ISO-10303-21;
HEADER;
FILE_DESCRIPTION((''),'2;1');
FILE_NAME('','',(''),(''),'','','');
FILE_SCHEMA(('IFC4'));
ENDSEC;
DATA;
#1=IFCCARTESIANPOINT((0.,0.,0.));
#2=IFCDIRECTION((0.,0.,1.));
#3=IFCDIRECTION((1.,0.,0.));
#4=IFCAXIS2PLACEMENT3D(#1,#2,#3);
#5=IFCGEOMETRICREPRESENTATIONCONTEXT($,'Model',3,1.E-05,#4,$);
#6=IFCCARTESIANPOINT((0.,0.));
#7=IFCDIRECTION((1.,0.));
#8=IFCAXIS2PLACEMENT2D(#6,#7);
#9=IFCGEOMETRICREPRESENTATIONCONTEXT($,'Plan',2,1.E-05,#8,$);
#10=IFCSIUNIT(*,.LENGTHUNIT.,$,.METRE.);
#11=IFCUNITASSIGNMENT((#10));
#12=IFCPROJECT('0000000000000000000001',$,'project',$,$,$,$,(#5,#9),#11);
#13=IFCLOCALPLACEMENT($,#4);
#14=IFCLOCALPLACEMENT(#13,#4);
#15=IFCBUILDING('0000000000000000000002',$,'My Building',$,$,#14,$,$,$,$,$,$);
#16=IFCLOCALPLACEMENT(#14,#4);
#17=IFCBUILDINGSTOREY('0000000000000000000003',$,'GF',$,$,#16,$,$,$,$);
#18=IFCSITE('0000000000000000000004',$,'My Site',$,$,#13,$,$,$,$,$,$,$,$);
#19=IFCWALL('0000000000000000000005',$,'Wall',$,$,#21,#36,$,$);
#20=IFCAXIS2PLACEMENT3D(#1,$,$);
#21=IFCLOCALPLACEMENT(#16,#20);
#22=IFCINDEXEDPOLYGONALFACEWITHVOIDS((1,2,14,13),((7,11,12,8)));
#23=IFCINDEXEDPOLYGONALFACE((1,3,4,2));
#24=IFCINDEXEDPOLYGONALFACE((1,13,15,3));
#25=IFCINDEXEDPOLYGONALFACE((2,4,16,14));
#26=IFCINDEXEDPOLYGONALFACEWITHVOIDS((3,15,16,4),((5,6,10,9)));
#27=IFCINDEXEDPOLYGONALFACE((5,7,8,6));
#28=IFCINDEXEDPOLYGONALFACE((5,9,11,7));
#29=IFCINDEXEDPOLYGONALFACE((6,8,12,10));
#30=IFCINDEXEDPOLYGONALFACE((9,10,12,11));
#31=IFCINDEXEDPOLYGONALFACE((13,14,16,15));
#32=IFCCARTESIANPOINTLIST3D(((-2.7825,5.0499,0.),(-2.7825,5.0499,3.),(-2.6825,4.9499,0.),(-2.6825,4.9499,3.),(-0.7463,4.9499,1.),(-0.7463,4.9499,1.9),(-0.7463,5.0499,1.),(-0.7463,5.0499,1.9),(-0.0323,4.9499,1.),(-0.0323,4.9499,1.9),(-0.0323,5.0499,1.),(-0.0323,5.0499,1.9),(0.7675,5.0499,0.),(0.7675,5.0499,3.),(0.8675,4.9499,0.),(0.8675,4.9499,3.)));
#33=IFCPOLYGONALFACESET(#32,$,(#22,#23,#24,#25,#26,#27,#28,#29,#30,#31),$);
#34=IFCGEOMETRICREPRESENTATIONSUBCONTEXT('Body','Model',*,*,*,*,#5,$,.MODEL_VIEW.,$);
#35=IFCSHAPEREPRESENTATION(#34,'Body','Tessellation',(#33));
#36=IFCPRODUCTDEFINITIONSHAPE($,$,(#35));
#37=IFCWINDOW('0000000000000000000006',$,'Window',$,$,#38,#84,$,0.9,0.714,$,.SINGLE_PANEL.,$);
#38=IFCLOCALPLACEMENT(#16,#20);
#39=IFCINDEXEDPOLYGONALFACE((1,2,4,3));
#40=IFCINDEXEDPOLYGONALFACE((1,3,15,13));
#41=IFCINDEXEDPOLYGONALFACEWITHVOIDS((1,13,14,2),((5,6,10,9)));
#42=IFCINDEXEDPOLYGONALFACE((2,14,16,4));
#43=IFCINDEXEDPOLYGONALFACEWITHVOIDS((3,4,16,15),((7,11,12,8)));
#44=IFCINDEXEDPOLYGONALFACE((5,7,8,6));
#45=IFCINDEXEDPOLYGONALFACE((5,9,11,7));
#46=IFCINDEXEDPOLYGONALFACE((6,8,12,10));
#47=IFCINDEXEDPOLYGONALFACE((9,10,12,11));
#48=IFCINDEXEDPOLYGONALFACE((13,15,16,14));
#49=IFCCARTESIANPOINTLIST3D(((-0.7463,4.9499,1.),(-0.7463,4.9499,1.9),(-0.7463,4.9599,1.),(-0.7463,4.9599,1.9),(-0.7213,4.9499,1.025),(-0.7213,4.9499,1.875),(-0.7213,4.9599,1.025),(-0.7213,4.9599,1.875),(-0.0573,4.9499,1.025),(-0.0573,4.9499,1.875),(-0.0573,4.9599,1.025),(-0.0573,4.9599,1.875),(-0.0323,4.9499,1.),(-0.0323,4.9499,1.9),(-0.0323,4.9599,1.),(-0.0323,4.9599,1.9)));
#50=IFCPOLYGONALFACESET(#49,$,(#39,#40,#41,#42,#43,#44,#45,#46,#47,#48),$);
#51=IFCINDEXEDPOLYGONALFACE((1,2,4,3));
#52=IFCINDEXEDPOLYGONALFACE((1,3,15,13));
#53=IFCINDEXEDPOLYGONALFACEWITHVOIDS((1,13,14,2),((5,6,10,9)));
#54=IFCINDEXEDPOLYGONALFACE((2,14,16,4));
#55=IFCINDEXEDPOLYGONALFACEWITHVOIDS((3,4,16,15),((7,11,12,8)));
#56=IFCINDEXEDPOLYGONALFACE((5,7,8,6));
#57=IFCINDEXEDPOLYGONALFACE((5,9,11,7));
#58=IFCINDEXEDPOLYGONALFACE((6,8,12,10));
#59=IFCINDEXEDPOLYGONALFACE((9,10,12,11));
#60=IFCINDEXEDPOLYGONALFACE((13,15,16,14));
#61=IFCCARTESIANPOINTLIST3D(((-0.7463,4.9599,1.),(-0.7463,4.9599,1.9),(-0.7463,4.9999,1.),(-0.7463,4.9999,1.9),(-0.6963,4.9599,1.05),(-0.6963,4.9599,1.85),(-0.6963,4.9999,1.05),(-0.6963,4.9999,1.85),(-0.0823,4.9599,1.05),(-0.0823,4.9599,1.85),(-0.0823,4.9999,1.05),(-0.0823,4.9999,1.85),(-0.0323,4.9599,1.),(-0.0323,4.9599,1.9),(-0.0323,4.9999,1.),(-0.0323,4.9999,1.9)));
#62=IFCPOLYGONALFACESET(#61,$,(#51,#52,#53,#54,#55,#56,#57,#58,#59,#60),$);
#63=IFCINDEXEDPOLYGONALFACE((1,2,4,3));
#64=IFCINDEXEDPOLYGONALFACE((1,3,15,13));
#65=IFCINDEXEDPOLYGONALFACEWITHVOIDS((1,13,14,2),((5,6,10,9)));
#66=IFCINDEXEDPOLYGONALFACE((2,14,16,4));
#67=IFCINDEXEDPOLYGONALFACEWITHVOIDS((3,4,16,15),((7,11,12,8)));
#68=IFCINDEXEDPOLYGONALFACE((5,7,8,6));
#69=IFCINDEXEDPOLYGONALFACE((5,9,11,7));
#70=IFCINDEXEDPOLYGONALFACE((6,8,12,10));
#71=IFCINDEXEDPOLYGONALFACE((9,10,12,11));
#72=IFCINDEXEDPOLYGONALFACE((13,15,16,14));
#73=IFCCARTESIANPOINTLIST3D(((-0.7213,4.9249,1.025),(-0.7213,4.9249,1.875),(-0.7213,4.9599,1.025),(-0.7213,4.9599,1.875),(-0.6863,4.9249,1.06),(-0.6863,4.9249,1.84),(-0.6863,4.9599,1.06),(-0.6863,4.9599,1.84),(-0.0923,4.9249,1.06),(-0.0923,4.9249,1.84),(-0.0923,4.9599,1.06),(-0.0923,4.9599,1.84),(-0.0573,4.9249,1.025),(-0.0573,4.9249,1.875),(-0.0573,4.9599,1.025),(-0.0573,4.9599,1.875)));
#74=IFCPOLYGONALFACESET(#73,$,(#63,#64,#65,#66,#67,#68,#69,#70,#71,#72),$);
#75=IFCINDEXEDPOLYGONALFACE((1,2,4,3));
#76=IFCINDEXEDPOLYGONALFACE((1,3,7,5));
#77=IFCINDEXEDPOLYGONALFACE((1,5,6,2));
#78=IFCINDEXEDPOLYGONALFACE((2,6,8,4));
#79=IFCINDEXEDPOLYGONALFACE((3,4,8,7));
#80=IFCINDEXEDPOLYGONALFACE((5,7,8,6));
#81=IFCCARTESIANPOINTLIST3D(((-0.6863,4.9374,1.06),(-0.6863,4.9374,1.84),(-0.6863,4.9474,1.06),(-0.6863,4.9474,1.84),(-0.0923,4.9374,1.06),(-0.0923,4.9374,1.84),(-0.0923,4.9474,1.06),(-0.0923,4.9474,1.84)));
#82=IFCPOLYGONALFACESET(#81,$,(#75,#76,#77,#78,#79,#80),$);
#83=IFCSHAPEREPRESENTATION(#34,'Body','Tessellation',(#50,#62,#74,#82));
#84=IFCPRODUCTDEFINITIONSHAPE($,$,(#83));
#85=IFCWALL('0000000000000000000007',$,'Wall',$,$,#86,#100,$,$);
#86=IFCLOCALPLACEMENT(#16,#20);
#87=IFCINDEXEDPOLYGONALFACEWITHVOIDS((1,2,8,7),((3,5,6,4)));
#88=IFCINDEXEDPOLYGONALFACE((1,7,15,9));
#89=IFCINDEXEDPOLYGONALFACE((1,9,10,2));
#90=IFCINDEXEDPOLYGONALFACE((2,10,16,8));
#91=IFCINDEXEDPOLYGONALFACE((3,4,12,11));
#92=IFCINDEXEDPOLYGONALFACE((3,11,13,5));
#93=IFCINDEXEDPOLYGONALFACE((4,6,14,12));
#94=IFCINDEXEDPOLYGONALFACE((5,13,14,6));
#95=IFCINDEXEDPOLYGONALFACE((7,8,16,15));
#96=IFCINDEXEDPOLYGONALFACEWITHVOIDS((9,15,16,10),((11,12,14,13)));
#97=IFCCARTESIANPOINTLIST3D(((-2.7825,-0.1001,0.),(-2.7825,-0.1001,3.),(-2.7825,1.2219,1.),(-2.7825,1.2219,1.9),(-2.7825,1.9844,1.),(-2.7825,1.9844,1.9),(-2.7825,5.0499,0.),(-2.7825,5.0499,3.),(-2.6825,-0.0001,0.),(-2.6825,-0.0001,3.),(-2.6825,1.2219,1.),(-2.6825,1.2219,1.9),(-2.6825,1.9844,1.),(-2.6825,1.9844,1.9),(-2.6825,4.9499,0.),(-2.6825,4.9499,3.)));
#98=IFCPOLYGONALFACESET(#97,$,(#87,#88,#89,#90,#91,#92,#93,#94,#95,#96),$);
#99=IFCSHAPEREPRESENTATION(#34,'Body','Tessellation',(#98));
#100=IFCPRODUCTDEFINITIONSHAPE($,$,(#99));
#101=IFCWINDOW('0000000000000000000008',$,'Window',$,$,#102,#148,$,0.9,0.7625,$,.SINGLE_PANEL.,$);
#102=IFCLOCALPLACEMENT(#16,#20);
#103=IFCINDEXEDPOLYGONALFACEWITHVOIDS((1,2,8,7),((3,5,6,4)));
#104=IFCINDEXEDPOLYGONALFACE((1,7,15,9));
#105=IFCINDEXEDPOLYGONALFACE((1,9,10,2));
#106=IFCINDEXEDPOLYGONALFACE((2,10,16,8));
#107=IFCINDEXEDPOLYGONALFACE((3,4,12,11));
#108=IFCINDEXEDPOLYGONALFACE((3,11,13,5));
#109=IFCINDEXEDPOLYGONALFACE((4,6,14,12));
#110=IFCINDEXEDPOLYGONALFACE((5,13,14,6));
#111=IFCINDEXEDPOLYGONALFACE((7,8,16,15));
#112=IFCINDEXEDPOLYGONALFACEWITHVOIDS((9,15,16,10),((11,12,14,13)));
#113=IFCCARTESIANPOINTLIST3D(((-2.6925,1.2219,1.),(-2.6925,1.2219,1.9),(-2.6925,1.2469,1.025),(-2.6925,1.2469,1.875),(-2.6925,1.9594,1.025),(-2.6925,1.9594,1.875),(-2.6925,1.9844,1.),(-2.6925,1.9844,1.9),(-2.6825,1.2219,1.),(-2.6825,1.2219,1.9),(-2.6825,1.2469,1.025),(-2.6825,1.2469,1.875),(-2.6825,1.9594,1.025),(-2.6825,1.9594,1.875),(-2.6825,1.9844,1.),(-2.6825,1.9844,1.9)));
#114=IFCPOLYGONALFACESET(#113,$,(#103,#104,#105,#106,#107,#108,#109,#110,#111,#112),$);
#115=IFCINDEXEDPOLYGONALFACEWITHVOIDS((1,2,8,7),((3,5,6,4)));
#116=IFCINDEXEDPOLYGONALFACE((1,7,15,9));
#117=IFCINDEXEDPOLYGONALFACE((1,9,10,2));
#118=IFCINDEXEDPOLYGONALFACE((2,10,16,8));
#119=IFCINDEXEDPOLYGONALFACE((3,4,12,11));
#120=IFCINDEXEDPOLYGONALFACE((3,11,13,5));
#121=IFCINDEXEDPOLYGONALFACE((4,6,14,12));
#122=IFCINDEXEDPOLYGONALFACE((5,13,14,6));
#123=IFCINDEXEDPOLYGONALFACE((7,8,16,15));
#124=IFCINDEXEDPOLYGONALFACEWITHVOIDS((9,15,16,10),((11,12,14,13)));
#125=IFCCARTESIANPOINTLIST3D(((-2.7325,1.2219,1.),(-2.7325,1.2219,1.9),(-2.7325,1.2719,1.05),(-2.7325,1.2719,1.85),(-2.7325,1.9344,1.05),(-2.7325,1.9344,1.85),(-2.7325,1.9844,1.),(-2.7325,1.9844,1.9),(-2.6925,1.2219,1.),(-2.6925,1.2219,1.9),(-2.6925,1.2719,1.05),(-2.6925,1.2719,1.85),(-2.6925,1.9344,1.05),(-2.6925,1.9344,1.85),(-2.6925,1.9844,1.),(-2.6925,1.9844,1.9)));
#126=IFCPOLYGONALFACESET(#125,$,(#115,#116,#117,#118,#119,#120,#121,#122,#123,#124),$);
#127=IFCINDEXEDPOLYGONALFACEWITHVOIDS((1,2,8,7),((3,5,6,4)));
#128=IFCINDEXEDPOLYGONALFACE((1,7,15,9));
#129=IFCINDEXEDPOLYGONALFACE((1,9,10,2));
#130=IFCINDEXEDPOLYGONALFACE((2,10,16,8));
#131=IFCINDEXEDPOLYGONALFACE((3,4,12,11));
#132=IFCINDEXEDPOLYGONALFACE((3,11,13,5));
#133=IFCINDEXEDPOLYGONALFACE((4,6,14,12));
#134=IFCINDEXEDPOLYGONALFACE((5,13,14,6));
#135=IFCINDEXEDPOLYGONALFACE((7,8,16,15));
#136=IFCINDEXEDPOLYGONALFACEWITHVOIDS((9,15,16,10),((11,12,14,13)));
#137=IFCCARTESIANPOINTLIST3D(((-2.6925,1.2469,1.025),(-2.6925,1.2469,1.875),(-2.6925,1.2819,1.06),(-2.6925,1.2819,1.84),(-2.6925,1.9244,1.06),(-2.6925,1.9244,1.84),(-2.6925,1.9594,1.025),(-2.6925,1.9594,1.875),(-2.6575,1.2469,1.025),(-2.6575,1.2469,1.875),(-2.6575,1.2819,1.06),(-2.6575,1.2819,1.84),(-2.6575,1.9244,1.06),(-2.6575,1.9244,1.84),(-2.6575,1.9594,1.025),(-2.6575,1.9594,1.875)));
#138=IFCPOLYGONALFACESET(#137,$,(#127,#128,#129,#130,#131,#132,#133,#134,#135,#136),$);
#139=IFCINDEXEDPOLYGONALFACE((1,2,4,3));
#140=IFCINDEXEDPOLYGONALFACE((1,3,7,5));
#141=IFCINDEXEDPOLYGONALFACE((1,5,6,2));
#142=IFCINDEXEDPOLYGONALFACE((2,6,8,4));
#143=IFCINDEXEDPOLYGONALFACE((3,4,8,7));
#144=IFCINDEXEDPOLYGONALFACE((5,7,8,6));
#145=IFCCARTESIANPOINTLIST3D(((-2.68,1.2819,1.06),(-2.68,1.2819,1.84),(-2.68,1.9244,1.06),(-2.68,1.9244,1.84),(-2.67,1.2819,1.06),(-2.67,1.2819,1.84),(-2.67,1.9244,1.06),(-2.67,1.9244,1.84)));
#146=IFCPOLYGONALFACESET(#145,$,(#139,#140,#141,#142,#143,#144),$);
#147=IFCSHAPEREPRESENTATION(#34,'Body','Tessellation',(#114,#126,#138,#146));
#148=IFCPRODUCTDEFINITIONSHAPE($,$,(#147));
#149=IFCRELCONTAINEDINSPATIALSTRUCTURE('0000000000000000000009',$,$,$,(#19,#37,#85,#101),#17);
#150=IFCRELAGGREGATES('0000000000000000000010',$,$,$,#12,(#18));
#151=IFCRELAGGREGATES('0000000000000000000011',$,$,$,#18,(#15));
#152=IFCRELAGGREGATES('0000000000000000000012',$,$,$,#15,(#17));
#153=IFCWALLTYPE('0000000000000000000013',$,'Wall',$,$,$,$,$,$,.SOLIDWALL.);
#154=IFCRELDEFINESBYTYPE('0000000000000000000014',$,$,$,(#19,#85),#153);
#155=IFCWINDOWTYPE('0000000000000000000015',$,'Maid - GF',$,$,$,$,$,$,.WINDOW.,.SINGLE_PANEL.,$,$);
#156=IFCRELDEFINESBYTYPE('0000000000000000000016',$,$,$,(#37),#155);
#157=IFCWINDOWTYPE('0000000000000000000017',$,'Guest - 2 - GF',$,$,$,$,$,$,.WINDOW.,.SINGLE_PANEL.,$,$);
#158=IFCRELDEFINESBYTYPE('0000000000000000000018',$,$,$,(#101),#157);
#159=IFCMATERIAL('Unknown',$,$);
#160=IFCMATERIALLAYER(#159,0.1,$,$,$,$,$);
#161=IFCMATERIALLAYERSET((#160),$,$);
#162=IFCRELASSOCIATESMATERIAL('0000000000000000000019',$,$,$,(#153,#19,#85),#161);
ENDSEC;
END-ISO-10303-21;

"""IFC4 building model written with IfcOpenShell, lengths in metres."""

from ifc_helpers import new_model, entity, si_unit, frame, origin_with_axes, origin_2d_with_axis, place, context, subcontext, project, spatial, line, indexed_curve, outline, extrude, shape, source, transform, mapped, material, layer, layer_set, layer_usage, type_object, type_shapes, element, fill, save


model = new_model("IFC4")

# Units and contexts
model_context = context("Model", 3, precision=1e-05, world=origin_with_axes())
plan_context = context("Plan", 2, precision=1e-05, world=origin_2d_with_axis())
body_context_1 = subcontext(model_context, "Body", "Model", "MODEL_VIEW")
body_context_2 = subcontext(plan_context, "Body", "Plan", "PLAN_VIEW")
ifc_project = project(units=[si_unit("LENGTHUNIT", "METRE")], contexts=[model_context, plan_context])

# Site, building, storey
site_placement = place(None, origin_with_axes())
site = spatial("IfcSite", under=ifc_project, at=site_placement, Name="My Site")
building_placement = place(site_placement, origin_with_axes())
building = spatial("IfcBuilding", under=site, at=building_placement, Name="My Building")
storey_placement = place(building_placement, origin_with_axes())
storey = spatial("IfcBuildingStorey", under=building, at=storey_placement, Name="GF")

# Shared definitions
ifc_material_1 = material(Name="Unknown")

# Shared definitions
ifc_layer_1 = layer(ifc_material_1, 0.1)
ifc_layer_set_1 = layer_set([ifc_layer_1])
wall_type = type_object("IfcWallType", Name="Wall", PredefinedType="SOLIDWALL", material=ifc_layer_set_1)

# Walls, openings, windows
ifc_layer_usage_1 = layer_usage(ifc_layer_set_1, "AXIS2", "POSITIVE", 0.0)
wall_1_placement = place(storey_placement, frame((0.7675, 5.0499, 0.0), z_axis=(0.0, 0.0, 1.0), x_axis=(-1.0, 0.0, 0.0)))
wall_1 = element("IfcWall", 1, at=wall_1_placement, inside=storey, type_object=wall_type, material=ifc_layer_usage_1, Name="Wall", context=body_context_1, shape_type="SweptSolid", body=[
    extrude(outline(indexed_curve([(0.0, 0.0), (-0.1, 0.1), (3.45, 0.1), (3.55, 0.0)], segments=[line(1, 2, 3, 4, 1)])), origin_with_axes(), (0.0, 0.0, 1.0), 3.0),
])
shared_shape_1 = source(origin_with_axes(), body_context_1, "Body", "SweptSolid", [
    extrude(outline(indexed_curve([(0.0, 0.0), (0.714, 0.0), (0.714, 0.9), (0.0, 0.9)], segments=[line(1, 2, 3, 4, 1)])), frame((0.0, -0.6, 0.0), z_axis=(0.0, -1.0, 0.0), x_axis=(1.0, 0.0, 0.0)), (0.0, 0.0, -1.0), 1.2),
])
opening_1_placement = place(wall_1_placement, frame((0.7998, 0.0, 1.0), z_axis=(0.0, 0.0, 1.0), x_axis=(1.0, 0.0, 0.0)))
opening_1 = element("IfcOpeningElement", 2, at=opening_1_placement, cuts=wall_1, PredefinedType="OPENING", context=body_context_1, shape_type="MappedRepresentation", body=[
    mapped(shared_shape_1, transform((0.0, 0.0, 0.0), x_axis=(1.0, 0.0, 0.0), y_axis=(0.0, 1.0, 0.0), z_axis=(0.0, 0.0, 1.0), scale=1.0)),
])
window_type_1 = type_object("IfcWindowType", Name="Maid - GF", PartitioningType="SINGLE_PANEL", PredefinedType="WINDOW")
shared_shape_2 = source(origin_with_axes(), body_context_1, "Body", "SweptSolid", [
    extrude(outline(indexed_curve([(0.0, 0.0), (0.714, 0.0), (0.714, 0.9), (0.0, 0.9)], segments=[line(1, 2, 3, 4, 1)]), holes=[indexed_curve([(0.025, 0.025), (0.689, 0.025), (0.689, 0.875), (0.025, 0.875)], segments=[line(1, 2, 3, 4, 1)])]), frame((0.0, 0.09, 0.0), z_axis=(0.0, -1.0, 0.0), x_axis=(1.0, 0.0, 0.0)), (0.0, 0.0, -1.0), 0.01),
    extrude(outline(indexed_curve([(0.0, 0.0), (0.714, 0.0), (0.714, 0.9), (0.0, 0.9)], segments=[line(1, 2, 3, 4, 1)]), holes=[indexed_curve([(0.05, 0.05), (0.664, 0.05), (0.664, 0.85), (0.05, 0.85)], segments=[line(1, 2, 3, 4, 1)])]), frame((0.0, 0.05, 0.0), z_axis=(0.0, -1.0, 0.0), x_axis=(1.0, 0.0, 0.0)), (0.0, 0.0, -1.0), 0.04),
    extrude(outline(indexed_curve([(0.0, 0.0), (0.664, 0.0), (0.664, 0.85), (0.0, 0.85)], segments=[line(1, 2, 3, 4, 1)]), holes=[indexed_curve([(0.035, 0.035), (0.629, 0.035), (0.629, 0.815), (0.035, 0.815)], segments=[line(1, 2, 3, 4, 1)])]), frame((0.025, 0.09, 0.025), z_axis=(0.0, -1.0, 0.0), x_axis=(1.0, 0.0, 0.0)), (0.0, 0.0, -1.0), 0.035),
    extrude(outline(indexed_curve([(0.035, 0.035), (0.629, 0.035), (0.629, 0.815), (0.035, 0.815)], segments=[line(1, 2, 3, 4, 1)])), frame((0.025, 0.1025, 0.025), z_axis=(0.0, -1.0, 0.0), x_axis=(1.0, 0.0, 0.0)), (0.0, 0.0, -1.0), 0.01),
])
shared_shape_3 = source(origin_with_axes(), body_context_2, "Body", "Curve2D", [
    entity("IfcIndexedPolyCurve", entity("IfcCartesianPointList2D", [[0.05, 0.05], [0.664, 0.05]])),
    entity("IfcIndexedPolyCurve", entity("IfcCartesianPointList2D", [[0.0, 0.1], [0.025, 0.1], [0.025, 0.09], [0.05, 0.09], [0.05, 0.05], [0.0, 0.05]]), [entity("IfcLineIndex", [1, 2, 3, 4, 5, 6, 1])]),
    entity("IfcIndexedPolyCurve", entity("IfcCartesianPointList2D", [[0.714, 0.1], [0.689, 0.1], [0.689, 0.09], [0.664, 0.09], [0.664, 0.05], [0.714, 0.05]]), [entity("IfcLineIndex", [1, 2, 3, 4, 5, 6, 1])]),
    entity("IfcIndexedPolyCurve", entity("IfcCartesianPointList2D", [[0.025, 0.09], [0.06, 0.09], [0.06, 0.125], [0.025, 0.125]]), [entity("IfcLineIndex", [1, 2, 3, 4, 1])]),
    entity("IfcIndexedPolyCurve", entity("IfcCartesianPointList2D", [[0.689, 0.09], [0.654, 0.09], [0.654, 0.125], [0.689, 0.125]]), [entity("IfcLineIndex", [1, 2, 3, 4, 1])]),
    entity("IfcIndexedPolyCurve", entity("IfcCartesianPointList2D", [[0.06, 0.09], [0.654, 0.09]])),
    entity("IfcIndexedPolyCurve", entity("IfcCartesianPointList2D", [[0.06, 0.125], [0.654, 0.125]])),
    entity("IfcIndexedPolyCurve", entity("IfcCartesianPointList2D", [[0.06, 0.1075], [0.654, 0.1075]])),
])
type_shapes(window_type_1, [shared_shape_2, shared_shape_3])
window_1_placement = place(opening_1_placement, frame((0.0, 0.0, 0.0), z_axis=(0.0, 0.0, 1.0), x_axis=(1.0, 0.0, 0.0)))
window_1 = element("IfcWindow", 3, at=window_1_placement, inside=storey, type_object=window_type_1, Name="Window", OverallHeight=0.9, OverallWidth=0.714, PartitioningType="SINGLE_PANEL", shapes=[
    shape(body_context_1, "Body", "MappedRepresentation", [mapped(shared_shape_2, transform((0.0, 0.0, 0.0), x_axis=(1.0, 0.0, 0.0), y_axis=(0.0, 1.0, 0.0), z_axis=(0.0, 0.0, 1.0), scale=1.0))]),
    shape(body_context_2, "Body", "MappedRepresentation", [mapped(shared_shape_3, transform((0.0, 0.0, 0.0), x_axis=(1.0, 0.0, 0.0), y_axis=(0.0, 1.0, 0.0), z_axis=(0.0, 0.0, 1.0), scale=1.0))]),
])
fill(opening_1, window_1)
ifc_layer_usage_2 = layer_usage(ifc_layer_set_1, "AXIS2", "POSITIVE", 0.0)
wall_2_placement = place(storey_placement, frame((-2.7825, 5.0499, 0.0), z_axis=(0.0, 0.0, 1.0), x_axis=(0.0, -1.0, 0.0)))
wall_2 = element("IfcWall", 4, at=wall_2_placement, inside=storey, type_object=wall_type, material=ifc_layer_usage_2, Name="Wall", context=body_context_1, shape_type="SweptSolid", body=[
    extrude(outline(indexed_curve([(0.0, 0.0), (0.1, 0.1), (5.05, 0.1), (5.15, 0.0)], segments=[line(1, 2, 3, 4, 1)])), origin_with_axes(), (0.0, 0.0, 1.0), 3.0),
])
shared_shape_4 = source(origin_with_axes(), body_context_1, "Body", "SweptSolid", [
    extrude(outline(indexed_curve([(0.0, 0.0), (0.7625, 0.0), (0.7625, 0.9), (0.0, 0.9)], segments=[line(1, 2, 3, 4, 1)])), frame((0.0, -0.6, 0.0), z_axis=(0.0, -1.0, 0.0), x_axis=(1.0, 0.0, 0.0)), (0.0, 0.0, -1.0), 1.2),
])
opening_2_placement = place(wall_2_placement, frame((3.0656, 0.0, 1.0), z_axis=(0.0, 0.0, 1.0), x_axis=(1.0, 0.0, 0.0)))
opening_2 = element("IfcOpeningElement", 5, at=opening_2_placement, cuts=wall_2, PredefinedType="OPENING", context=body_context_1, shape_type="MappedRepresentation", body=[
    mapped(shared_shape_4, transform((0.0, 0.0, 0.0), x_axis=(1.0, 0.0, 0.0), y_axis=(0.0, 1.0, 0.0), z_axis=(0.0, 0.0, 1.0), scale=1.0)),
])
window_type_2 = type_object("IfcWindowType", Name="Guest - 2 - GF", PartitioningType="SINGLE_PANEL", PredefinedType="WINDOW")
shared_shape_5 = source(origin_with_axes(), body_context_1, "Body", "SweptSolid", [
    extrude(outline(indexed_curve([(0.0, 0.0), (0.7625, 0.0), (0.7625, 0.9), (0.0, 0.9)], segments=[line(1, 2, 3, 4, 1)]), holes=[indexed_curve([(0.025, 0.025), (0.7375, 0.025), (0.7375, 0.875), (0.025, 0.875)], segments=[line(1, 2, 3, 4, 1)])]), frame((0.0, 0.09, 0.0), z_axis=(0.0, -1.0, 0.0), x_axis=(1.0, 0.0, 0.0)), (0.0, 0.0, -1.0), 0.01),
    extrude(outline(indexed_curve([(0.0, 0.0), (0.7625, 0.0), (0.7625, 0.9), (0.0, 0.9)], segments=[line(1, 2, 3, 4, 1)]), holes=[indexed_curve([(0.05, 0.05), (0.7125, 0.05), (0.7125, 0.85), (0.05, 0.85)], segments=[line(1, 2, 3, 4, 1)])]), frame((0.0, 0.05, 0.0), z_axis=(0.0, -1.0, 0.0), x_axis=(1.0, 0.0, 0.0)), (0.0, 0.0, -1.0), 0.04),
    extrude(outline(indexed_curve([(0.0, 0.0), (0.7125, 0.0), (0.7125, 0.85), (0.0, 0.85)], segments=[line(1, 2, 3, 4, 1)]), holes=[indexed_curve([(0.035, 0.035), (0.6775, 0.035), (0.6775, 0.815), (0.035, 0.815)], segments=[line(1, 2, 3, 4, 1)])]), frame((0.025, 0.09, 0.025), z_axis=(0.0, -1.0, 0.0), x_axis=(1.0, 0.0, 0.0)), (0.0, 0.0, -1.0), 0.035),
    extrude(outline(indexed_curve([(0.035, 0.035), (0.6775, 0.035), (0.6775, 0.815), (0.035, 0.815)], segments=[line(1, 2, 3, 4, 1)])), frame((0.025, 0.1025, 0.025), z_axis=(0.0, -1.0, 0.0), x_axis=(1.0, 0.0, 0.0)), (0.0, 0.0, -1.0), 0.01),
])
shared_shape_6 = source(origin_with_axes(), body_context_2, "Body", "Curve2D", [
    entity("IfcIndexedPolyCurve", entity("IfcCartesianPointList2D", [[0.05, 0.05], [0.7125, 0.05]])),
    entity("IfcIndexedPolyCurve", entity("IfcCartesianPointList2D", [[0.0, 0.1], [0.025, 0.1], [0.025, 0.09], [0.05, 0.09], [0.05, 0.05], [0.0, 0.05]]), [entity("IfcLineIndex", [1, 2, 3, 4, 5, 6, 1])]),
    entity("IfcIndexedPolyCurve", entity("IfcCartesianPointList2D", [[0.7625, 0.1], [0.7375, 0.1], [0.7375, 0.09], [0.7125, 0.09], [0.7125, 0.05], [0.7625, 0.05]]), [entity("IfcLineIndex", [1, 2, 3, 4, 5, 6, 1])]),
    entity("IfcIndexedPolyCurve", entity("IfcCartesianPointList2D", [[0.025, 0.09], [0.06, 0.09], [0.06, 0.125], [0.025, 0.125]]), [entity("IfcLineIndex", [1, 2, 3, 4, 1])]),
    entity("IfcIndexedPolyCurve", entity("IfcCartesianPointList2D", [[0.7375, 0.09], [0.7025, 0.09], [0.7025, 0.125], [0.7375, 0.125]]), [entity("IfcLineIndex", [1, 2, 3, 4, 1])]),
    entity("IfcIndexedPolyCurve", entity("IfcCartesianPointList2D", [[0.06, 0.09], [0.7025, 0.09]])),
    entity("IfcIndexedPolyCurve", entity("IfcCartesianPointList2D", [[0.06, 0.125], [0.7025, 0.125]])),
    entity("IfcIndexedPolyCurve", entity("IfcCartesianPointList2D", [[0.06, 0.1075], [0.7025, 0.1075]])),
])
type_shapes(window_type_2, [shared_shape_5, shared_shape_6])
window_2_placement = place(opening_2_placement, frame((0.0, 0.0, 0.0), z_axis=(0.0, 0.0, 1.0), x_axis=(1.0, 0.0, 0.0)))
window_2 = element("IfcWindow", 6, at=window_2_placement, inside=storey, type_object=window_type_2, Name="Window", OverallHeight=0.9, OverallWidth=0.7625, PartitioningType="SINGLE_PANEL", shapes=[
    shape(body_context_1, "Body", "MappedRepresentation", [mapped(shared_shape_5, transform((0.0, 0.0, 0.0), x_axis=(1.0, 0.0, 0.0), y_axis=(0.0, 1.0, 0.0), z_axis=(0.0, 0.0, 1.0), scale=1.0))]),
    shape(body_context_2, "Body", "MappedRepresentation", [mapped(shared_shape_6, transform((0.0, 0.0, 0.0), x_axis=(1.0, 0.0, 0.0), y_axis=(0.0, 1.0, 0.0), z_axis=(0.0, 0.0, 1.0), scale=1.0))]),
])
fill(opening_2, window_2)

save(model, "model.ifc")
